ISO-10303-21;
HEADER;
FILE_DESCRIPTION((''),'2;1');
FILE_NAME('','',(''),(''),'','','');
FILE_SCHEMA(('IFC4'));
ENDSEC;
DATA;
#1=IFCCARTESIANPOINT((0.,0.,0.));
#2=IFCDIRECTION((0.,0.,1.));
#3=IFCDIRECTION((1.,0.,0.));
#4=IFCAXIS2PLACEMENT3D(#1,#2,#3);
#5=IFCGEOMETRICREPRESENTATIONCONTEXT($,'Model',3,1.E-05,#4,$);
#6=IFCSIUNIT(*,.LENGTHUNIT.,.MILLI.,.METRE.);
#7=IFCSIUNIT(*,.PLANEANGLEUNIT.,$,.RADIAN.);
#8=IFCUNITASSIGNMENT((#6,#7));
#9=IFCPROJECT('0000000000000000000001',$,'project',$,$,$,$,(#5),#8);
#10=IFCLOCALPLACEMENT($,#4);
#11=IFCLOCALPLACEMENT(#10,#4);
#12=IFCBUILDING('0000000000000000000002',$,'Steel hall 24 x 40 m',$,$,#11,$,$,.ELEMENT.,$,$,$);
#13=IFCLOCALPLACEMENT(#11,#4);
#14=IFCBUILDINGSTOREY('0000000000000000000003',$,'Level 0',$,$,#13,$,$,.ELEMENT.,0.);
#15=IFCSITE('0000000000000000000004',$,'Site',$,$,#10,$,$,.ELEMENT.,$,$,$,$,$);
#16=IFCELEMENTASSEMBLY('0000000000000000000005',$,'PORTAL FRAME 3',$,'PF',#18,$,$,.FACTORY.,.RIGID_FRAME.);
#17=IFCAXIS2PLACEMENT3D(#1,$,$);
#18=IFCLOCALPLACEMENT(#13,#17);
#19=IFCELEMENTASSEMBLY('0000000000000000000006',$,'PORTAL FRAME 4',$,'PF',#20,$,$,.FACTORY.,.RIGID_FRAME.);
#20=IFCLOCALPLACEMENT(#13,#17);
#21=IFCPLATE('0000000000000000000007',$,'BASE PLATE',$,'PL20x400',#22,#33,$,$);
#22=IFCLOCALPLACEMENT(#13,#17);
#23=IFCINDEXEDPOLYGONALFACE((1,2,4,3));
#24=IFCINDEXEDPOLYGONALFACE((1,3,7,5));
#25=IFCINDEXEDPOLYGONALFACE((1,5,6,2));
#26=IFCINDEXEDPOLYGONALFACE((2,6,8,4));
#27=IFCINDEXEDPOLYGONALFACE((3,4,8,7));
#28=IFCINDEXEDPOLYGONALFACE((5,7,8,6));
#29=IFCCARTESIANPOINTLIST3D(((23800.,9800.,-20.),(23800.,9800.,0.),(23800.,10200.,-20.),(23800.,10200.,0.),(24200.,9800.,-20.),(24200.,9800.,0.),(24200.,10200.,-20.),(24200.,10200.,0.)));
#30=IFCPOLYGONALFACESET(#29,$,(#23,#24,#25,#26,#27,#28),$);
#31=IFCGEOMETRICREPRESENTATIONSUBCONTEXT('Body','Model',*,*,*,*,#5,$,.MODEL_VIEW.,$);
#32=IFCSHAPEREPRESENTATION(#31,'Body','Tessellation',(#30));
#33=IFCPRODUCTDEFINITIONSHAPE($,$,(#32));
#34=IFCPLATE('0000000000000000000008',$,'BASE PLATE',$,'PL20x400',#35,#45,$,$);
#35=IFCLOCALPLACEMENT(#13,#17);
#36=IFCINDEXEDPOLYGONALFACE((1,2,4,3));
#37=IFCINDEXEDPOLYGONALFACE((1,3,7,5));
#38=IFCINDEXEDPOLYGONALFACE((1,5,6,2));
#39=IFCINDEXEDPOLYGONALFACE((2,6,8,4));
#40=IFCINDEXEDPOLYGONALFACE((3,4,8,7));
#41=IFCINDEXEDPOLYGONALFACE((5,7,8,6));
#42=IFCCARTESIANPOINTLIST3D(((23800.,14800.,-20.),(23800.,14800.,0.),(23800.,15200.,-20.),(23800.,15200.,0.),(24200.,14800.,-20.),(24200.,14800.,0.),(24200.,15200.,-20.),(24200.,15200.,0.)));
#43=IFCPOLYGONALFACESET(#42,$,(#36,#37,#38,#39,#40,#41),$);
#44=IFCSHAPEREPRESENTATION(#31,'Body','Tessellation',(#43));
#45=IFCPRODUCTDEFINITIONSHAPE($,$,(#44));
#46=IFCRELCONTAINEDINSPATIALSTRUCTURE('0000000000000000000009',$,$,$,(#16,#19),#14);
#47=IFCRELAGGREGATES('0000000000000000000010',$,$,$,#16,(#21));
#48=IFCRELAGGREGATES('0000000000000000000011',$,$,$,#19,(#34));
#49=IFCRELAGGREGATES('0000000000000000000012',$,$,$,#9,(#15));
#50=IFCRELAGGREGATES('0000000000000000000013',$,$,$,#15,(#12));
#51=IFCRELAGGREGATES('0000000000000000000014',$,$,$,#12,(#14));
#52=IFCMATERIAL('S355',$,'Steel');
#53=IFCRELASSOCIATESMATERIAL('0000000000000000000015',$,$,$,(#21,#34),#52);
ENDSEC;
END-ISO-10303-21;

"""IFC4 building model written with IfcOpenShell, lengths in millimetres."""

from ifc_helpers import new_model, si_unit, frame, origin_with_axes, place, context, subcontext, project, spatial, rectangle, extrude, material, element, aggregate, save


model = new_model("IFC4")

# Units and contexts
model_context = context("Model", 3, precision=1e-05, world=origin_with_axes())
body_context = subcontext(model_context, "Body", "Model", "MODEL_VIEW")
ifc_project = project(units=[si_unit("LENGTHUNIT", "METRE", prefix="MILLI"), si_unit("PLANEANGLEUNIT", "RADIAN")], contexts=[model_context])

# Site, building, storey
site_placement = place(None, origin_with_axes())
site = spatial("IfcSite", under=ifc_project, at=site_placement, Name="Site", CompositionType="ELEMENT")
building_placement = place(site_placement, origin_with_axes())
building = spatial("IfcBuilding", under=site, at=building_placement, Name="Steel hall 24 x 40 m", CompositionType="ELEMENT")
storey_placement = place(building_placement, origin_with_axes())
storey = spatial("IfcBuildingStorey", under=building, at=storey_placement, Name="Level 0", CompositionType="ELEMENT", Elevation=0.0)

# Element assemblies
ifc_material = material(Name="S355", Category="Steel")
assembly_1_placement = place(storey_placement, frame((0.0, 10000.0, 0.0), z_axis=(0.0, 0.0, 1.0), x_axis=(1.0, 0.0, 0.0)))
assembly_1 = element("IfcElementAssembly", 1, at=assembly_1_placement, inside=storey, Name="PORTAL FRAME 3", ObjectType="PF", AssemblyPlace="FACTORY", PredefinedType="RIGID_FRAME")
assembly_2_placement = place(storey_placement, frame((0.0, 15000.0, 0.0), z_axis=(0.0, 0.0, 1.0), x_axis=(1.0, 0.0, 0.0)))
assembly_2 = element("IfcElementAssembly", 2, at=assembly_2_placement, inside=storey, Name="PORTAL FRAME 4", ObjectType="PF", AssemblyPlace="FACTORY", PredefinedType="RIGID_FRAME")

# Plates
plate_1_placement = place(storey_placement, frame((24000.0, 10000.0, -20.0), z_axis=(0.0, 0.0, 1.0), x_axis=(1.0, 0.0, 0.0)))
plate_1 = element("IfcPlate", 3, at=plate_1_placement, material=ifc_material, Name="BASE PLATE", ObjectType="PL20x400", context=body_context, shape_type="SweptSolid", body=[
    extrude(rectangle(XDim=400.0, YDim=400.0), origin_with_axes(), (0.0, 0.0, 1.0), 20.0),
])
aggregate(assembly_1, [plate_1])
plate_2_placement = place(storey_placement, frame((24000.0, 15000.0, -20.0), z_axis=(0.0, 0.0, 1.0), x_axis=(1.0, 0.0, 0.0)))
plate_2 = element("IfcPlate", 4, at=plate_2_placement, material=ifc_material, Name="BASE PLATE", ObjectType="PL20x400", context=body_context, shape_type="SweptSolid", body=[
    extrude(rectangle(XDim=400.0, YDim=400.0), origin_with_axes(), (0.0, 0.0, 1.0), 20.0),
])
aggregate(assembly_2, [plate_2])

save(model, "model.ifc")
